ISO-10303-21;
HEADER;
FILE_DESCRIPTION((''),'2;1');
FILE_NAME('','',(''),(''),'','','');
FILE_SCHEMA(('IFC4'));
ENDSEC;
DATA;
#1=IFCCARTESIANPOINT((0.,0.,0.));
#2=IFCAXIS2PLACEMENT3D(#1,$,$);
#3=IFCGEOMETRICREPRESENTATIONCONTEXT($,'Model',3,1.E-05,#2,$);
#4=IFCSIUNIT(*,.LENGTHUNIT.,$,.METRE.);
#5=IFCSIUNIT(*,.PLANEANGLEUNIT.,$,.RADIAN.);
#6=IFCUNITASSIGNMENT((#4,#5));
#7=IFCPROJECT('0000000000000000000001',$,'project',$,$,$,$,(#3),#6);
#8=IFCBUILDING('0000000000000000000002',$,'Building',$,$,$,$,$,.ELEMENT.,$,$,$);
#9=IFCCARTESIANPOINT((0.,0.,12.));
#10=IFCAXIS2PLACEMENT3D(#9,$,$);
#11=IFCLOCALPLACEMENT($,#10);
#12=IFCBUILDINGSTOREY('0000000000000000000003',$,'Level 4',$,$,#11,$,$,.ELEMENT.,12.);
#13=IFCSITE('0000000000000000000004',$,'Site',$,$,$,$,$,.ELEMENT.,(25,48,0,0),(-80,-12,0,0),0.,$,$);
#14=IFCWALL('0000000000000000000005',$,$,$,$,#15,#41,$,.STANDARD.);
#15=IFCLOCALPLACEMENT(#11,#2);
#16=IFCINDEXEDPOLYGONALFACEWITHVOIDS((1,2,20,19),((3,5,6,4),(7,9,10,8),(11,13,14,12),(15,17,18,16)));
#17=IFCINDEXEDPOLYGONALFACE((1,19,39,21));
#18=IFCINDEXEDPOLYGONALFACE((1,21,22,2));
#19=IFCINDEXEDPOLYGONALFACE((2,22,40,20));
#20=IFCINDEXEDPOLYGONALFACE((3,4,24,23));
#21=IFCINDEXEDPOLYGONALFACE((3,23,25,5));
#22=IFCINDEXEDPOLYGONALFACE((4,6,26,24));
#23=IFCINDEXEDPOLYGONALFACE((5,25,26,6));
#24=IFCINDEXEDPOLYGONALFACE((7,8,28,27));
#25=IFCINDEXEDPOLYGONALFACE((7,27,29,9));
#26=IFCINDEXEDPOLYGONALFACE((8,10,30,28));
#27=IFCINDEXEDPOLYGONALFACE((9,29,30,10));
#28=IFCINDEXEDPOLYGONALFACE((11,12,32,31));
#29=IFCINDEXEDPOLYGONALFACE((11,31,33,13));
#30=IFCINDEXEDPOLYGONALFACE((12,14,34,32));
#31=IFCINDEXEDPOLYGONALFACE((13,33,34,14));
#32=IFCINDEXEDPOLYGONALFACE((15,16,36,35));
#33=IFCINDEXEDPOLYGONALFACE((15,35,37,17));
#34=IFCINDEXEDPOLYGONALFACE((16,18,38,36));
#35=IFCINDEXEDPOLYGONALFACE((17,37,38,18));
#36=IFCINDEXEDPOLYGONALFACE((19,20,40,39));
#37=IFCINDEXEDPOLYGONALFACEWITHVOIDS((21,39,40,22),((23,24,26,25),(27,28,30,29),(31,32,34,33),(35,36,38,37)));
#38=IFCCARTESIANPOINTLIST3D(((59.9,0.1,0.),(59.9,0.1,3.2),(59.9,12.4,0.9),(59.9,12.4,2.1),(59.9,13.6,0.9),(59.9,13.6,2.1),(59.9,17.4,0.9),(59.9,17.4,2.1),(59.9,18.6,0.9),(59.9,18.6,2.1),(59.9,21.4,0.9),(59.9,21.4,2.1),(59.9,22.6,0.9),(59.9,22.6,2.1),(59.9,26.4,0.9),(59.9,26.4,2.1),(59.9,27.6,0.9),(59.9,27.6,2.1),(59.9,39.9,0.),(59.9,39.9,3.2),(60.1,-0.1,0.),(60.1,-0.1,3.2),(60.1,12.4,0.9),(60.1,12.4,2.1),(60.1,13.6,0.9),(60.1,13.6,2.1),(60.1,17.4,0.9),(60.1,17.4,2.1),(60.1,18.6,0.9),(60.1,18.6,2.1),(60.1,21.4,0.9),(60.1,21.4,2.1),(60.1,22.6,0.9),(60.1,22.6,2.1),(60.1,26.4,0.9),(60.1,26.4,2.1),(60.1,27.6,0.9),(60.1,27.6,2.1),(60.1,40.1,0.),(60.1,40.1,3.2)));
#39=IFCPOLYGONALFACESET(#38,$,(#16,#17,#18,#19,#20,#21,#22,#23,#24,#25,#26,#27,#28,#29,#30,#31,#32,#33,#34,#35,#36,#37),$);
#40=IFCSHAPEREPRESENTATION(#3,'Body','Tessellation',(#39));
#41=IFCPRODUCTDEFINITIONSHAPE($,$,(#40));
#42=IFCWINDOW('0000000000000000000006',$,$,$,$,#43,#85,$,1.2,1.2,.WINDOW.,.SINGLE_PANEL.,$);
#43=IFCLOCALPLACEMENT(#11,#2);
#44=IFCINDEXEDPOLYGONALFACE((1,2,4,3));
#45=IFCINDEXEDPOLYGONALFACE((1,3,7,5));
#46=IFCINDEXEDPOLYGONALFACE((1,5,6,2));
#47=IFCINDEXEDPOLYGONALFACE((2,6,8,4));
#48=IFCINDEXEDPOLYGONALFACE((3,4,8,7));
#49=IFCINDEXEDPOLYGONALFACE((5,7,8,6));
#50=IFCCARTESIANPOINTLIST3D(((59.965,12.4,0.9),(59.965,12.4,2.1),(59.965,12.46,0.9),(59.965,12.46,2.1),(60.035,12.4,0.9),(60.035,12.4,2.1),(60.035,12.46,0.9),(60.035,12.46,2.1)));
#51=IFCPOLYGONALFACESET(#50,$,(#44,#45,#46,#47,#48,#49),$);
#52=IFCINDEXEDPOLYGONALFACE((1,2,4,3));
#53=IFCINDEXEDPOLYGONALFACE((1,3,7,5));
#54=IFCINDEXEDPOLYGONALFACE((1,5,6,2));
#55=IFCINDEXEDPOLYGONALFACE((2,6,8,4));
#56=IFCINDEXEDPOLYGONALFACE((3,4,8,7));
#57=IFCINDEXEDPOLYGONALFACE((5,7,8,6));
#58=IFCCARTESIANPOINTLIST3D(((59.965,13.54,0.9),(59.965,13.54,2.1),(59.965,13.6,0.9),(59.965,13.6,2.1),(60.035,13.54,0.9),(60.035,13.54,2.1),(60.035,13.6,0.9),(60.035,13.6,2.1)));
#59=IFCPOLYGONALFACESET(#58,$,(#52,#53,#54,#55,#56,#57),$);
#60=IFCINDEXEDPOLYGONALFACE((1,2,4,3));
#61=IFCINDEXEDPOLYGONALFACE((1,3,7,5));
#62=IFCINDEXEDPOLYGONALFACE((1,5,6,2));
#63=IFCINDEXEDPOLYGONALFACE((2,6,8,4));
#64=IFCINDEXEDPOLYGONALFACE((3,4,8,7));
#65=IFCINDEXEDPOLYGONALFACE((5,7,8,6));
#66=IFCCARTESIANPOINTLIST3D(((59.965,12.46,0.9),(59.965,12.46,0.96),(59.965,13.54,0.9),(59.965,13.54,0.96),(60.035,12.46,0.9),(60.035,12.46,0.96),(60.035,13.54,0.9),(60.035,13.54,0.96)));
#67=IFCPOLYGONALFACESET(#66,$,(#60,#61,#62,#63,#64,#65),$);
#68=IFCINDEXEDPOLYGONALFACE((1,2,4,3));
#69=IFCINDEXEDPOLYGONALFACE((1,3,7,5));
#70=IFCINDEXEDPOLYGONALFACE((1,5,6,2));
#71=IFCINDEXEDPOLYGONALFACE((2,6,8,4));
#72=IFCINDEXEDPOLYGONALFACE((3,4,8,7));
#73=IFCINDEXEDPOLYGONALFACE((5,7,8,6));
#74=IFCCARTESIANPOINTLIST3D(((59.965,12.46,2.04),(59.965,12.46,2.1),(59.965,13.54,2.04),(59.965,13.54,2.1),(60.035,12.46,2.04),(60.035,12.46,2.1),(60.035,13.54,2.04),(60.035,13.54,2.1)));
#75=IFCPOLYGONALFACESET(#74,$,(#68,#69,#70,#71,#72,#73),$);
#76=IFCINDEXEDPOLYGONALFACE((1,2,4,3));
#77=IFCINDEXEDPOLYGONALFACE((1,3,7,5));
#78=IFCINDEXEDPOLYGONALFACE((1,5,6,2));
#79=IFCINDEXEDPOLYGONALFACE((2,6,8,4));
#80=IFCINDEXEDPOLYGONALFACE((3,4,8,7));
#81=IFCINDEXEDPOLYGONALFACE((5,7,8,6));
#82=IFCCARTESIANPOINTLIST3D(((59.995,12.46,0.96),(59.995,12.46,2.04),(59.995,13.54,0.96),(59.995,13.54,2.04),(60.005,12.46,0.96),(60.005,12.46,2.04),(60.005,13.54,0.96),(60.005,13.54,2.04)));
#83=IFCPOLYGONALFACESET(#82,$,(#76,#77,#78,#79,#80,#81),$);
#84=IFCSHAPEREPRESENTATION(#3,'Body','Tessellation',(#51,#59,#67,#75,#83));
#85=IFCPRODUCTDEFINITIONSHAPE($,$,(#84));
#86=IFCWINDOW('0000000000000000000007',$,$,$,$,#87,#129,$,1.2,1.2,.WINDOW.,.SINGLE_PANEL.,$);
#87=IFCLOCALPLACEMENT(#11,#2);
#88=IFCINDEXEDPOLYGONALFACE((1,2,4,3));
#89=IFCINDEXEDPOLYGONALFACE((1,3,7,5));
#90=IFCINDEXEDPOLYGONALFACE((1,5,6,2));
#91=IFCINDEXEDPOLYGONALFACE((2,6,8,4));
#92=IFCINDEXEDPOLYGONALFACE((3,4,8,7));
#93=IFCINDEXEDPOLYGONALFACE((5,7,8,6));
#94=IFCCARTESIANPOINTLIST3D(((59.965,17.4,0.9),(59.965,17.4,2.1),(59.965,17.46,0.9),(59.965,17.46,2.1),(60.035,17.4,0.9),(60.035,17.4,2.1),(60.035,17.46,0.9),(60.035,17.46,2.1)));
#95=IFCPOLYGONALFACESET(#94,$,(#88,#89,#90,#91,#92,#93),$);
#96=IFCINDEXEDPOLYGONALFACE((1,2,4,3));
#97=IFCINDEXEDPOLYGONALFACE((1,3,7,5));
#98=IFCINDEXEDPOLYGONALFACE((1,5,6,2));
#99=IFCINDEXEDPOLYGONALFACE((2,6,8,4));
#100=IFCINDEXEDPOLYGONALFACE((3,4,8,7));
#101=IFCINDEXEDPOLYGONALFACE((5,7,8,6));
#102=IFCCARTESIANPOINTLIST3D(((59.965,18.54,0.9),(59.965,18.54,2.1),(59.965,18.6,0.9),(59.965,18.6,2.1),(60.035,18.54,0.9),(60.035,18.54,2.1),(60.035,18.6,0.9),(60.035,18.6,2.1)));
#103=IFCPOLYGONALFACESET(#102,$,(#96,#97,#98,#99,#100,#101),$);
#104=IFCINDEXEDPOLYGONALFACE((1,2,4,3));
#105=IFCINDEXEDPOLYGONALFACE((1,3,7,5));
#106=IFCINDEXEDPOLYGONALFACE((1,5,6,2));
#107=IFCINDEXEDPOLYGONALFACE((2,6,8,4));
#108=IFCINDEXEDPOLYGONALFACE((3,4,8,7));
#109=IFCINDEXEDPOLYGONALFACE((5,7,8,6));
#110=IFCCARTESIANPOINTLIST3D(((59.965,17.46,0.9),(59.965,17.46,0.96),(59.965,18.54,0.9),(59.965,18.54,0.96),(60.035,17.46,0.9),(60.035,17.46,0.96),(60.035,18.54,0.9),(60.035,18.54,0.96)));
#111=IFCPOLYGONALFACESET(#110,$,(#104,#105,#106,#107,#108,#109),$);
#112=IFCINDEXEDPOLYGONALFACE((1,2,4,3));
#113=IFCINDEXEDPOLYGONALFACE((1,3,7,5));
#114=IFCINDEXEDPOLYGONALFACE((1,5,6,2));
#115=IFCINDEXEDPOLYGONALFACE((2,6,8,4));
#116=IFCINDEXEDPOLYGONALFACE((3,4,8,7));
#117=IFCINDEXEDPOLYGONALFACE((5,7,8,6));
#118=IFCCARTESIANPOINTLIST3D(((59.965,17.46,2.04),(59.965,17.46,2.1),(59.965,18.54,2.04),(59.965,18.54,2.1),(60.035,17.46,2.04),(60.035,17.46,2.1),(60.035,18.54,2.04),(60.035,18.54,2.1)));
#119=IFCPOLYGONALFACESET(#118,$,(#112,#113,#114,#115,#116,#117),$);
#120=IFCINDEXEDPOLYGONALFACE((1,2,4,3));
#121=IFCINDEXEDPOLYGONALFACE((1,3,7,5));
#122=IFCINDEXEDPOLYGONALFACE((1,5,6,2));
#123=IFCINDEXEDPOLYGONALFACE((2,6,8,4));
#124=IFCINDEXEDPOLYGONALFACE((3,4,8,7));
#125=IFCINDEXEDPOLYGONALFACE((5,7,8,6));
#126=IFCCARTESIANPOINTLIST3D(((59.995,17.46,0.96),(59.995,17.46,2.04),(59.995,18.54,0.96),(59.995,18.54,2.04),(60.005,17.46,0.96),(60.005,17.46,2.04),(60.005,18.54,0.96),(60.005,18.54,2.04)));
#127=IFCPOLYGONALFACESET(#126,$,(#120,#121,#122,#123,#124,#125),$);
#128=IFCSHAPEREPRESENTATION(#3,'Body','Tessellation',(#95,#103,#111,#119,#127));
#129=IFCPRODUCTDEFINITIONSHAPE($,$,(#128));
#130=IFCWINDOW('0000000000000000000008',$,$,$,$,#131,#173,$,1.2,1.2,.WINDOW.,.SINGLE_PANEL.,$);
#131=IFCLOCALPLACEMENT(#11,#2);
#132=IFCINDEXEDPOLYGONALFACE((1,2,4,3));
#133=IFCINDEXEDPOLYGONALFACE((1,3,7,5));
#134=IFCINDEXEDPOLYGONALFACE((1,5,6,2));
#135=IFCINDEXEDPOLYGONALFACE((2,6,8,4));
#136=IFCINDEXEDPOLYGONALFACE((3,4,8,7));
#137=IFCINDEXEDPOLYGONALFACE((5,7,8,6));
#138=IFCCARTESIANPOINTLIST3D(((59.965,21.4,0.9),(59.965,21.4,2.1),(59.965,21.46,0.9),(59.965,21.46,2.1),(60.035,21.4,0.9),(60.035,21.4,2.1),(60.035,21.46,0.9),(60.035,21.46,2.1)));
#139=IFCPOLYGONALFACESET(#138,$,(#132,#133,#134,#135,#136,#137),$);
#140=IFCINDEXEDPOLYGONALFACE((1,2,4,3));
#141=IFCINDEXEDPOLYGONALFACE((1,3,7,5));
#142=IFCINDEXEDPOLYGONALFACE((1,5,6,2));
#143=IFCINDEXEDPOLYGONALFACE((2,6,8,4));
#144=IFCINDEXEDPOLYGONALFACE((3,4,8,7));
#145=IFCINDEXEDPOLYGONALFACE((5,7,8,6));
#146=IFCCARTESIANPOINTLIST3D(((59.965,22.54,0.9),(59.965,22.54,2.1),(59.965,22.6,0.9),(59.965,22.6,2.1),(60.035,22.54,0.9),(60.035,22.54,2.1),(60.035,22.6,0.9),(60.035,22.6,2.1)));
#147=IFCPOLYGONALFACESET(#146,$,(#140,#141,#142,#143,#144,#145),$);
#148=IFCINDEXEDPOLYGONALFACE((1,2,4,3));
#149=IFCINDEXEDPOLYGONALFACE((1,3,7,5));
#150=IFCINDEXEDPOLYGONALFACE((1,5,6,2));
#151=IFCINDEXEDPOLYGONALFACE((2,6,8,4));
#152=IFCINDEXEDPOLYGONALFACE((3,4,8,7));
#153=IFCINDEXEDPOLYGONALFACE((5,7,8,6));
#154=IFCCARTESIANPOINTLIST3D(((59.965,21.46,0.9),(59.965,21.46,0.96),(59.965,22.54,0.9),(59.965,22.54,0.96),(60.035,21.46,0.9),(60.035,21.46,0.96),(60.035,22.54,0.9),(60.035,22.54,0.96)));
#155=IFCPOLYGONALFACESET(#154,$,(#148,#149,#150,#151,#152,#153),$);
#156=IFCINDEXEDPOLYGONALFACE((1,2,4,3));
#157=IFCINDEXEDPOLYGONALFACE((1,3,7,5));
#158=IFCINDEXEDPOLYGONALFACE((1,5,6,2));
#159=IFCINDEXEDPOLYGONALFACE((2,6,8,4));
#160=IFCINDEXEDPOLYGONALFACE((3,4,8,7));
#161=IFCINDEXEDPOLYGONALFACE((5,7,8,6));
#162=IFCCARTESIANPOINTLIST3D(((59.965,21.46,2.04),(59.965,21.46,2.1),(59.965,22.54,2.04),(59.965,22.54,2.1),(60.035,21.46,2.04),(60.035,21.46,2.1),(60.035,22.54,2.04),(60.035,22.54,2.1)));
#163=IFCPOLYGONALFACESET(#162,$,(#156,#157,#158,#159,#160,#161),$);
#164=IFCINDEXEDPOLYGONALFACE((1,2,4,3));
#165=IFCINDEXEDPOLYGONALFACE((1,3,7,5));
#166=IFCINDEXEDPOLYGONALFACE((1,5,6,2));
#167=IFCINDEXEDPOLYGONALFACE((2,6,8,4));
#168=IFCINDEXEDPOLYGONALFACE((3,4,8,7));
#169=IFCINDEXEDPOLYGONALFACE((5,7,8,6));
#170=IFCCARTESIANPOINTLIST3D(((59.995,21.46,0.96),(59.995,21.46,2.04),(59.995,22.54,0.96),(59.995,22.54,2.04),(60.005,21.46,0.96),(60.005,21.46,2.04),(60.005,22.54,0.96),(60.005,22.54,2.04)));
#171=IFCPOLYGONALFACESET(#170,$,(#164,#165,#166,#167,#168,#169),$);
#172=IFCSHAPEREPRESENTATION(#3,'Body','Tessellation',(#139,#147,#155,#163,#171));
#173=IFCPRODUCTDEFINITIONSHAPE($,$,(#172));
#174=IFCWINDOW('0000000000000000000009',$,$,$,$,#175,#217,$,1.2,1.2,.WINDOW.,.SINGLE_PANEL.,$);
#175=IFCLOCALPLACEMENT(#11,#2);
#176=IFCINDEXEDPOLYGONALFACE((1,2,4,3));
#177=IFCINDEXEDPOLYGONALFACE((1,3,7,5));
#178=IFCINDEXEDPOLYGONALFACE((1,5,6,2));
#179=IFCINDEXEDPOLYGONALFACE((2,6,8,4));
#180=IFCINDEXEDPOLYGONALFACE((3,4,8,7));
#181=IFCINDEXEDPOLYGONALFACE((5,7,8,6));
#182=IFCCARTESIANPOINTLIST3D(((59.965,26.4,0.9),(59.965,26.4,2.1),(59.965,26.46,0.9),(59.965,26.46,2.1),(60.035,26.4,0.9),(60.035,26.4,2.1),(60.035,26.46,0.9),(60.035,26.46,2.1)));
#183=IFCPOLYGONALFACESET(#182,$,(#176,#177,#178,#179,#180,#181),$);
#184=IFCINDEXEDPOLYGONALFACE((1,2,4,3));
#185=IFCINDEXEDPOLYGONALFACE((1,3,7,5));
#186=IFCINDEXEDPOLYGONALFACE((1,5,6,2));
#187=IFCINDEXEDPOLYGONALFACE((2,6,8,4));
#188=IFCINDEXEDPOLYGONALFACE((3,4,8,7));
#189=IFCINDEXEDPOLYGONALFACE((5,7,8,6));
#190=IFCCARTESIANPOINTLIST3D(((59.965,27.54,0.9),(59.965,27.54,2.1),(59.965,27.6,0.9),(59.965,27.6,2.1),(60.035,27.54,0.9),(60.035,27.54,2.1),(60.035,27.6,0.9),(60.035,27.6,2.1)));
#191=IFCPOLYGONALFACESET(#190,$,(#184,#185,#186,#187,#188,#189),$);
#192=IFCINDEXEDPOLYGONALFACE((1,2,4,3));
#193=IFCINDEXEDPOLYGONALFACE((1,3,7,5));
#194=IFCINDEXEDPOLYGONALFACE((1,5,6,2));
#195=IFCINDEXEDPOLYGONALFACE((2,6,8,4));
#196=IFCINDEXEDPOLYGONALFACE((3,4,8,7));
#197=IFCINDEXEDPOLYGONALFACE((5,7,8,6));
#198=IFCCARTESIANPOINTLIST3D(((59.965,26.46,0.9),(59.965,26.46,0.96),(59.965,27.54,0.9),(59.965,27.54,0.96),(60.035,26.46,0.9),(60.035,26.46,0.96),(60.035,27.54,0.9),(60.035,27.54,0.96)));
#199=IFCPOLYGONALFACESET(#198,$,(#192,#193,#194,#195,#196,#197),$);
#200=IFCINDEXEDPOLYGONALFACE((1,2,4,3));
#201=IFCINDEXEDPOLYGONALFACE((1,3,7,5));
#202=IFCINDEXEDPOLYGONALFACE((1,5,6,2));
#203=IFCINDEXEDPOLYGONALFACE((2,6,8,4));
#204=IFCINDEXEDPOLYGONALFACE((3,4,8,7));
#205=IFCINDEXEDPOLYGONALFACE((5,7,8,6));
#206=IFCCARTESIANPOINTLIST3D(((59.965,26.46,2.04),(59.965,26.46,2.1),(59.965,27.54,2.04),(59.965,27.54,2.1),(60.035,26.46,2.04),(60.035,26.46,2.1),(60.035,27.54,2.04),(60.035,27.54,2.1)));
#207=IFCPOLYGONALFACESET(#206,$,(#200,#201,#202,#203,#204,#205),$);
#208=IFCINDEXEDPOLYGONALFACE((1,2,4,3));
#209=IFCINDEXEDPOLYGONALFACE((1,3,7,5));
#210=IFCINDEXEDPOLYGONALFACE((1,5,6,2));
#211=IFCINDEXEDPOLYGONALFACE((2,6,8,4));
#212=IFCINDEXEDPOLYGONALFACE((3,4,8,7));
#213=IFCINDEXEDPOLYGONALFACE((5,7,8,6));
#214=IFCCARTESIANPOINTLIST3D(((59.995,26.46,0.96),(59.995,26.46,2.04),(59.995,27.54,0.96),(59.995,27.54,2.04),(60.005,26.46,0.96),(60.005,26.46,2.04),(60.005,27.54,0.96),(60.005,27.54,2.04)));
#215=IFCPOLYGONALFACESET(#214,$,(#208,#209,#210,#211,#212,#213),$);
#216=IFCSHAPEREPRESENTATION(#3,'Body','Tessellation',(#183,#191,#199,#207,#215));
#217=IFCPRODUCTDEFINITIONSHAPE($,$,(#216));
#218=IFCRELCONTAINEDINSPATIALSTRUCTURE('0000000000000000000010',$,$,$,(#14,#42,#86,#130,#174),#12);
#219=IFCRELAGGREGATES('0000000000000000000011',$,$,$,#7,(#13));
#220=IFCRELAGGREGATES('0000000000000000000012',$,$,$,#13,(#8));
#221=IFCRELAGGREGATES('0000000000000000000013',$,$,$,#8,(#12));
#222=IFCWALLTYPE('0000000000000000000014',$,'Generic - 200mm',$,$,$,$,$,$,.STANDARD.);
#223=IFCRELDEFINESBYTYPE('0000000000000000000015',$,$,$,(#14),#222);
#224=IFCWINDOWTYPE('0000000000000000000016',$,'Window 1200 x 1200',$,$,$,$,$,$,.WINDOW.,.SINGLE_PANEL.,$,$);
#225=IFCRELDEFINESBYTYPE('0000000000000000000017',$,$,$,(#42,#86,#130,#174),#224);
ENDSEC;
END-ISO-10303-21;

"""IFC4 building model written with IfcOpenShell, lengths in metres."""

from ifc_helpers import new_model, si_unit, frame, frame_2d, origin, origin_with_axes, origin_2d, place, context, project, spatial, polyline, rectangle, outline, extrude, type_object, element, fill, save


model = new_model("IFC4")

# Units and contexts
model_context = context("Model", 3, precision=1e-05, world=origin())
ifc_project = project(units=[si_unit("LENGTHUNIT", "METRE"), si_unit("PLANEANGLEUNIT", "RADIAN")], contexts=[model_context])

# Site, building, storey
site = spatial("IfcSite", under=ifc_project, Name="Site", CompositionType="ELEMENT", RefLatitude=(25, 48, 0, 0), RefLongitude=(-80, -12, 0, 0), RefElevation=0.0)
building = spatial("IfcBuilding", under=site, Name="Building", CompositionType="ELEMENT")
storey_placement = place(None, frame((0.0, 0.0, 12.0)))
storey = spatial("IfcBuildingStorey", under=building, at=storey_placement, Name="Level 4", CompositionType="ELEMENT", Elevation=12.0)

# Wall, openings, windows
wall_type = type_object("IfcWallType", Name="Generic - 200mm", PredefinedType="STANDARD")
wall_1_placement = place(None, frame((60.0, 0.0, 12.0), z_axis=(0.0, 0.0, 1.0), x_axis=(0.0, 1.0, 0.0)))
wall_1 = element("IfcWall", 1, at=wall_1_placement, inside=storey, type_object=wall_type, PredefinedType="STANDARD", context=model_context, shape_type="SweptSolid", body=[
    extrude(outline(polyline([(-0.1, -0.1), (40.1, -0.1), (39.9, 0.1), (0.1, 0.1), (-0.1, -0.1)])), origin(), (0.0, 0.0, 1.0), 3.2),
])
opening_1_placement = place(wall_1_placement, frame((13.0, 0.0, 0.9), z_axis=(0.0, 0.0, 1.0), x_axis=(1.0, 0.0, 0.0)))
opening_1 = element("IfcOpeningElement", 2, at=opening_1_placement, cuts=wall_1, PredefinedType="OPENING", context=model_context, shape_type="SweptSolid", body=[
    extrude(rectangle(XDim=1.2, YDim=0.202, at=origin_2d()), origin(), (0.0, 0.0, 1.0), 1.2),
])
opening_2_placement = place(wall_1_placement, frame((18.0, 0.0, 0.9), z_axis=(0.0, 0.0, 1.0), x_axis=(1.0, 0.0, 0.0)))
opening_2 = element("IfcOpeningElement", 3, at=opening_2_placement, cuts=wall_1, PredefinedType="OPENING", context=model_context, shape_type="SweptSolid", body=[
    extrude(rectangle(XDim=1.2, YDim=0.202, at=origin_2d()), origin(), (0.0, 0.0, 1.0), 1.2),
])
opening_3_placement = place(wall_1_placement, frame((22.0, 0.0, 0.9), z_axis=(0.0, 0.0, 1.0), x_axis=(1.0, 0.0, 0.0)))
opening_3 = element("IfcOpeningElement", 4, at=opening_3_placement, cuts=wall_1, PredefinedType="OPENING", context=model_context, shape_type="SweptSolid", body=[
    extrude(rectangle(XDim=1.2, YDim=0.202, at=origin_2d()), origin(), (0.0, 0.0, 1.0), 1.2),
])
opening_4_placement = place(wall_1_placement, frame((27.0, 0.0, 0.9), z_axis=(0.0, 0.0, 1.0), x_axis=(1.0, 0.0, 0.0)))
opening_4 = element("IfcOpeningElement", 5, at=opening_4_placement, cuts=wall_1, PredefinedType="OPENING", context=model_context, shape_type="SweptSolid", body=[
    extrude(rectangle(XDim=1.2, YDim=0.202, at=origin_2d()), origin(), (0.0, 0.0, 1.0), 1.2),
])
window_type = type_object("IfcWindowType", Name="Window 1200 x 1200", PartitioningType="SINGLE_PANEL", PredefinedType="WINDOW")
window_1_placement = place(opening_1_placement, origin_with_axes())
window_1 = element("IfcWindow", 6, at=window_1_placement, inside=storey, type_object=window_type, OverallHeight=1.2, OverallWidth=1.2, PartitioningType="SINGLE_PANEL", PredefinedType="WINDOW", context=model_context, shape_type="SweptSolid", body=[
    extrude(rectangle(XDim=0.06, YDim=0.07, at=frame_2d((-0.57, 0.0))), origin(), (0.0, 0.0, 1.0), 1.2),
    extrude(rectangle(XDim=0.06, YDim=0.07, at=frame_2d((0.57, 0.0))), origin(), (0.0, 0.0, 1.0), 1.2),
    extrude(rectangle(XDim=1.08, YDim=0.07, at=origin_2d()), origin(), (0.0, 0.0, 1.0), 0.06),
    extrude(rectangle(XDim=1.08, YDim=0.07, at=origin_2d()), frame((0.0, 0.0, 1.14)), (0.0, 0.0, 1.0), 0.06),
    extrude(rectangle(XDim=1.08, YDim=0.01, at=origin_2d()), frame((0.0, 0.0, 0.06)), (0.0, 0.0, 1.0), 1.08),
])
fill(opening_1, window_1)
window_2_placement = place(opening_2_placement, origin_with_axes())
window_2 = element("IfcWindow", 7, at=window_2_placement, inside=storey, type_object=window_type, OverallHeight=1.2, OverallWidth=1.2, PartitioningType="SINGLE_PANEL", PredefinedType="WINDOW", context=model_context, shape_type="SweptSolid", body=[
    extrude(rectangle(XDim=0.06, YDim=0.07, at=frame_2d((-0.57, 0.0))), origin(), (0.0, 0.0, 1.0), 1.2),
    extrude(rectangle(XDim=0.06, YDim=0.07, at=frame_2d((0.57, 0.0))), origin(), (0.0, 0.0, 1.0), 1.2),
    extrude(rectangle(XDim=1.08, YDim=0.07, at=origin_2d()), origin(), (0.0, 0.0, 1.0), 0.06),
    extrude(rectangle(XDim=1.08, YDim=0.07, at=origin_2d()), frame((0.0, 0.0, 1.14)), (0.0, 0.0, 1.0), 0.06),
    extrude(rectangle(XDim=1.08, YDim=0.01, at=origin_2d()), frame((0.0, 0.0, 0.06)), (0.0, 0.0, 1.0), 1.08),
])
fill(opening_2, window_2)
window_3_placement = place(opening_3_placement, origin_with_axes())
window_3 = element("IfcWindow", 8, at=window_3_placement, inside=storey, type_object=window_type, OverallHeight=1.2, OverallWidth=1.2, PartitioningType="SINGLE_PANEL", PredefinedType="WINDOW", context=model_context, shape_type="SweptSolid", body=[
    extrude(rectangle(XDim=0.06, YDim=0.07, at=frame_2d((-0.57, 0.0))), origin(), (0.0, 0.0, 1.0), 1.2),
    extrude(rectangle(XDim=0.06, YDim=0.07, at=frame_2d((0.57, 0.0))), origin(), (0.0, 0.0, 1.0), 1.2),
    extrude(rectangle(XDim=1.08, YDim=0.07, at=origin_2d()), origin(), (0.0, 0.0, 1.0), 0.06),
    extrude(rectangle(XDim=1.08, YDim=0.07, at=origin_2d()), frame((0.0, 0.0, 1.14)), (0.0, 0.0, 1.0), 0.06),
    extrude(rectangle(XDim=1.08, YDim=0.01, at=origin_2d()), frame((0.0, 0.0, 0.06)), (0.0, 0.0, 1.0), 1.08),
])
fill(opening_3, window_3)
window_4_placement = place(opening_4_placement, origin_with_axes())
window_4 = element("IfcWindow", 9, at=window_4_placement, inside=storey, type_object=window_type, OverallHeight=1.2, OverallWidth=1.2, PartitioningType="SINGLE_PANEL", PredefinedType="WINDOW", context=model_context, shape_type="SweptSolid", body=[
    extrude(rectangle(XDim=0.06, YDim=0.07, at=frame_2d((-0.57, 0.0))), origin(), (0.0, 0.0, 1.0), 1.2),
    extrude(rectangle(XDim=0.06, YDim=0.07, at=frame_2d((0.57, 0.0))), origin(), (0.0, 0.0, 1.0), 1.2),
    extrude(rectangle(XDim=1.08, YDim=0.07, at=origin_2d()), origin(), (0.0, 0.0, 1.0), 0.06),
    extrude(rectangle(XDim=1.08, YDim=0.07, at=origin_2d()), frame((0.0, 0.0, 1.14)), (0.0, 0.0, 1.0), 0.06),
    extrude(rectangle(XDim=1.08, YDim=0.01, at=origin_2d()), frame((0.0, 0.0, 0.06)), (0.0, 0.0, 1.0), 1.08),
])
fill(opening_4, window_4)

save(model, "model.ifc")
